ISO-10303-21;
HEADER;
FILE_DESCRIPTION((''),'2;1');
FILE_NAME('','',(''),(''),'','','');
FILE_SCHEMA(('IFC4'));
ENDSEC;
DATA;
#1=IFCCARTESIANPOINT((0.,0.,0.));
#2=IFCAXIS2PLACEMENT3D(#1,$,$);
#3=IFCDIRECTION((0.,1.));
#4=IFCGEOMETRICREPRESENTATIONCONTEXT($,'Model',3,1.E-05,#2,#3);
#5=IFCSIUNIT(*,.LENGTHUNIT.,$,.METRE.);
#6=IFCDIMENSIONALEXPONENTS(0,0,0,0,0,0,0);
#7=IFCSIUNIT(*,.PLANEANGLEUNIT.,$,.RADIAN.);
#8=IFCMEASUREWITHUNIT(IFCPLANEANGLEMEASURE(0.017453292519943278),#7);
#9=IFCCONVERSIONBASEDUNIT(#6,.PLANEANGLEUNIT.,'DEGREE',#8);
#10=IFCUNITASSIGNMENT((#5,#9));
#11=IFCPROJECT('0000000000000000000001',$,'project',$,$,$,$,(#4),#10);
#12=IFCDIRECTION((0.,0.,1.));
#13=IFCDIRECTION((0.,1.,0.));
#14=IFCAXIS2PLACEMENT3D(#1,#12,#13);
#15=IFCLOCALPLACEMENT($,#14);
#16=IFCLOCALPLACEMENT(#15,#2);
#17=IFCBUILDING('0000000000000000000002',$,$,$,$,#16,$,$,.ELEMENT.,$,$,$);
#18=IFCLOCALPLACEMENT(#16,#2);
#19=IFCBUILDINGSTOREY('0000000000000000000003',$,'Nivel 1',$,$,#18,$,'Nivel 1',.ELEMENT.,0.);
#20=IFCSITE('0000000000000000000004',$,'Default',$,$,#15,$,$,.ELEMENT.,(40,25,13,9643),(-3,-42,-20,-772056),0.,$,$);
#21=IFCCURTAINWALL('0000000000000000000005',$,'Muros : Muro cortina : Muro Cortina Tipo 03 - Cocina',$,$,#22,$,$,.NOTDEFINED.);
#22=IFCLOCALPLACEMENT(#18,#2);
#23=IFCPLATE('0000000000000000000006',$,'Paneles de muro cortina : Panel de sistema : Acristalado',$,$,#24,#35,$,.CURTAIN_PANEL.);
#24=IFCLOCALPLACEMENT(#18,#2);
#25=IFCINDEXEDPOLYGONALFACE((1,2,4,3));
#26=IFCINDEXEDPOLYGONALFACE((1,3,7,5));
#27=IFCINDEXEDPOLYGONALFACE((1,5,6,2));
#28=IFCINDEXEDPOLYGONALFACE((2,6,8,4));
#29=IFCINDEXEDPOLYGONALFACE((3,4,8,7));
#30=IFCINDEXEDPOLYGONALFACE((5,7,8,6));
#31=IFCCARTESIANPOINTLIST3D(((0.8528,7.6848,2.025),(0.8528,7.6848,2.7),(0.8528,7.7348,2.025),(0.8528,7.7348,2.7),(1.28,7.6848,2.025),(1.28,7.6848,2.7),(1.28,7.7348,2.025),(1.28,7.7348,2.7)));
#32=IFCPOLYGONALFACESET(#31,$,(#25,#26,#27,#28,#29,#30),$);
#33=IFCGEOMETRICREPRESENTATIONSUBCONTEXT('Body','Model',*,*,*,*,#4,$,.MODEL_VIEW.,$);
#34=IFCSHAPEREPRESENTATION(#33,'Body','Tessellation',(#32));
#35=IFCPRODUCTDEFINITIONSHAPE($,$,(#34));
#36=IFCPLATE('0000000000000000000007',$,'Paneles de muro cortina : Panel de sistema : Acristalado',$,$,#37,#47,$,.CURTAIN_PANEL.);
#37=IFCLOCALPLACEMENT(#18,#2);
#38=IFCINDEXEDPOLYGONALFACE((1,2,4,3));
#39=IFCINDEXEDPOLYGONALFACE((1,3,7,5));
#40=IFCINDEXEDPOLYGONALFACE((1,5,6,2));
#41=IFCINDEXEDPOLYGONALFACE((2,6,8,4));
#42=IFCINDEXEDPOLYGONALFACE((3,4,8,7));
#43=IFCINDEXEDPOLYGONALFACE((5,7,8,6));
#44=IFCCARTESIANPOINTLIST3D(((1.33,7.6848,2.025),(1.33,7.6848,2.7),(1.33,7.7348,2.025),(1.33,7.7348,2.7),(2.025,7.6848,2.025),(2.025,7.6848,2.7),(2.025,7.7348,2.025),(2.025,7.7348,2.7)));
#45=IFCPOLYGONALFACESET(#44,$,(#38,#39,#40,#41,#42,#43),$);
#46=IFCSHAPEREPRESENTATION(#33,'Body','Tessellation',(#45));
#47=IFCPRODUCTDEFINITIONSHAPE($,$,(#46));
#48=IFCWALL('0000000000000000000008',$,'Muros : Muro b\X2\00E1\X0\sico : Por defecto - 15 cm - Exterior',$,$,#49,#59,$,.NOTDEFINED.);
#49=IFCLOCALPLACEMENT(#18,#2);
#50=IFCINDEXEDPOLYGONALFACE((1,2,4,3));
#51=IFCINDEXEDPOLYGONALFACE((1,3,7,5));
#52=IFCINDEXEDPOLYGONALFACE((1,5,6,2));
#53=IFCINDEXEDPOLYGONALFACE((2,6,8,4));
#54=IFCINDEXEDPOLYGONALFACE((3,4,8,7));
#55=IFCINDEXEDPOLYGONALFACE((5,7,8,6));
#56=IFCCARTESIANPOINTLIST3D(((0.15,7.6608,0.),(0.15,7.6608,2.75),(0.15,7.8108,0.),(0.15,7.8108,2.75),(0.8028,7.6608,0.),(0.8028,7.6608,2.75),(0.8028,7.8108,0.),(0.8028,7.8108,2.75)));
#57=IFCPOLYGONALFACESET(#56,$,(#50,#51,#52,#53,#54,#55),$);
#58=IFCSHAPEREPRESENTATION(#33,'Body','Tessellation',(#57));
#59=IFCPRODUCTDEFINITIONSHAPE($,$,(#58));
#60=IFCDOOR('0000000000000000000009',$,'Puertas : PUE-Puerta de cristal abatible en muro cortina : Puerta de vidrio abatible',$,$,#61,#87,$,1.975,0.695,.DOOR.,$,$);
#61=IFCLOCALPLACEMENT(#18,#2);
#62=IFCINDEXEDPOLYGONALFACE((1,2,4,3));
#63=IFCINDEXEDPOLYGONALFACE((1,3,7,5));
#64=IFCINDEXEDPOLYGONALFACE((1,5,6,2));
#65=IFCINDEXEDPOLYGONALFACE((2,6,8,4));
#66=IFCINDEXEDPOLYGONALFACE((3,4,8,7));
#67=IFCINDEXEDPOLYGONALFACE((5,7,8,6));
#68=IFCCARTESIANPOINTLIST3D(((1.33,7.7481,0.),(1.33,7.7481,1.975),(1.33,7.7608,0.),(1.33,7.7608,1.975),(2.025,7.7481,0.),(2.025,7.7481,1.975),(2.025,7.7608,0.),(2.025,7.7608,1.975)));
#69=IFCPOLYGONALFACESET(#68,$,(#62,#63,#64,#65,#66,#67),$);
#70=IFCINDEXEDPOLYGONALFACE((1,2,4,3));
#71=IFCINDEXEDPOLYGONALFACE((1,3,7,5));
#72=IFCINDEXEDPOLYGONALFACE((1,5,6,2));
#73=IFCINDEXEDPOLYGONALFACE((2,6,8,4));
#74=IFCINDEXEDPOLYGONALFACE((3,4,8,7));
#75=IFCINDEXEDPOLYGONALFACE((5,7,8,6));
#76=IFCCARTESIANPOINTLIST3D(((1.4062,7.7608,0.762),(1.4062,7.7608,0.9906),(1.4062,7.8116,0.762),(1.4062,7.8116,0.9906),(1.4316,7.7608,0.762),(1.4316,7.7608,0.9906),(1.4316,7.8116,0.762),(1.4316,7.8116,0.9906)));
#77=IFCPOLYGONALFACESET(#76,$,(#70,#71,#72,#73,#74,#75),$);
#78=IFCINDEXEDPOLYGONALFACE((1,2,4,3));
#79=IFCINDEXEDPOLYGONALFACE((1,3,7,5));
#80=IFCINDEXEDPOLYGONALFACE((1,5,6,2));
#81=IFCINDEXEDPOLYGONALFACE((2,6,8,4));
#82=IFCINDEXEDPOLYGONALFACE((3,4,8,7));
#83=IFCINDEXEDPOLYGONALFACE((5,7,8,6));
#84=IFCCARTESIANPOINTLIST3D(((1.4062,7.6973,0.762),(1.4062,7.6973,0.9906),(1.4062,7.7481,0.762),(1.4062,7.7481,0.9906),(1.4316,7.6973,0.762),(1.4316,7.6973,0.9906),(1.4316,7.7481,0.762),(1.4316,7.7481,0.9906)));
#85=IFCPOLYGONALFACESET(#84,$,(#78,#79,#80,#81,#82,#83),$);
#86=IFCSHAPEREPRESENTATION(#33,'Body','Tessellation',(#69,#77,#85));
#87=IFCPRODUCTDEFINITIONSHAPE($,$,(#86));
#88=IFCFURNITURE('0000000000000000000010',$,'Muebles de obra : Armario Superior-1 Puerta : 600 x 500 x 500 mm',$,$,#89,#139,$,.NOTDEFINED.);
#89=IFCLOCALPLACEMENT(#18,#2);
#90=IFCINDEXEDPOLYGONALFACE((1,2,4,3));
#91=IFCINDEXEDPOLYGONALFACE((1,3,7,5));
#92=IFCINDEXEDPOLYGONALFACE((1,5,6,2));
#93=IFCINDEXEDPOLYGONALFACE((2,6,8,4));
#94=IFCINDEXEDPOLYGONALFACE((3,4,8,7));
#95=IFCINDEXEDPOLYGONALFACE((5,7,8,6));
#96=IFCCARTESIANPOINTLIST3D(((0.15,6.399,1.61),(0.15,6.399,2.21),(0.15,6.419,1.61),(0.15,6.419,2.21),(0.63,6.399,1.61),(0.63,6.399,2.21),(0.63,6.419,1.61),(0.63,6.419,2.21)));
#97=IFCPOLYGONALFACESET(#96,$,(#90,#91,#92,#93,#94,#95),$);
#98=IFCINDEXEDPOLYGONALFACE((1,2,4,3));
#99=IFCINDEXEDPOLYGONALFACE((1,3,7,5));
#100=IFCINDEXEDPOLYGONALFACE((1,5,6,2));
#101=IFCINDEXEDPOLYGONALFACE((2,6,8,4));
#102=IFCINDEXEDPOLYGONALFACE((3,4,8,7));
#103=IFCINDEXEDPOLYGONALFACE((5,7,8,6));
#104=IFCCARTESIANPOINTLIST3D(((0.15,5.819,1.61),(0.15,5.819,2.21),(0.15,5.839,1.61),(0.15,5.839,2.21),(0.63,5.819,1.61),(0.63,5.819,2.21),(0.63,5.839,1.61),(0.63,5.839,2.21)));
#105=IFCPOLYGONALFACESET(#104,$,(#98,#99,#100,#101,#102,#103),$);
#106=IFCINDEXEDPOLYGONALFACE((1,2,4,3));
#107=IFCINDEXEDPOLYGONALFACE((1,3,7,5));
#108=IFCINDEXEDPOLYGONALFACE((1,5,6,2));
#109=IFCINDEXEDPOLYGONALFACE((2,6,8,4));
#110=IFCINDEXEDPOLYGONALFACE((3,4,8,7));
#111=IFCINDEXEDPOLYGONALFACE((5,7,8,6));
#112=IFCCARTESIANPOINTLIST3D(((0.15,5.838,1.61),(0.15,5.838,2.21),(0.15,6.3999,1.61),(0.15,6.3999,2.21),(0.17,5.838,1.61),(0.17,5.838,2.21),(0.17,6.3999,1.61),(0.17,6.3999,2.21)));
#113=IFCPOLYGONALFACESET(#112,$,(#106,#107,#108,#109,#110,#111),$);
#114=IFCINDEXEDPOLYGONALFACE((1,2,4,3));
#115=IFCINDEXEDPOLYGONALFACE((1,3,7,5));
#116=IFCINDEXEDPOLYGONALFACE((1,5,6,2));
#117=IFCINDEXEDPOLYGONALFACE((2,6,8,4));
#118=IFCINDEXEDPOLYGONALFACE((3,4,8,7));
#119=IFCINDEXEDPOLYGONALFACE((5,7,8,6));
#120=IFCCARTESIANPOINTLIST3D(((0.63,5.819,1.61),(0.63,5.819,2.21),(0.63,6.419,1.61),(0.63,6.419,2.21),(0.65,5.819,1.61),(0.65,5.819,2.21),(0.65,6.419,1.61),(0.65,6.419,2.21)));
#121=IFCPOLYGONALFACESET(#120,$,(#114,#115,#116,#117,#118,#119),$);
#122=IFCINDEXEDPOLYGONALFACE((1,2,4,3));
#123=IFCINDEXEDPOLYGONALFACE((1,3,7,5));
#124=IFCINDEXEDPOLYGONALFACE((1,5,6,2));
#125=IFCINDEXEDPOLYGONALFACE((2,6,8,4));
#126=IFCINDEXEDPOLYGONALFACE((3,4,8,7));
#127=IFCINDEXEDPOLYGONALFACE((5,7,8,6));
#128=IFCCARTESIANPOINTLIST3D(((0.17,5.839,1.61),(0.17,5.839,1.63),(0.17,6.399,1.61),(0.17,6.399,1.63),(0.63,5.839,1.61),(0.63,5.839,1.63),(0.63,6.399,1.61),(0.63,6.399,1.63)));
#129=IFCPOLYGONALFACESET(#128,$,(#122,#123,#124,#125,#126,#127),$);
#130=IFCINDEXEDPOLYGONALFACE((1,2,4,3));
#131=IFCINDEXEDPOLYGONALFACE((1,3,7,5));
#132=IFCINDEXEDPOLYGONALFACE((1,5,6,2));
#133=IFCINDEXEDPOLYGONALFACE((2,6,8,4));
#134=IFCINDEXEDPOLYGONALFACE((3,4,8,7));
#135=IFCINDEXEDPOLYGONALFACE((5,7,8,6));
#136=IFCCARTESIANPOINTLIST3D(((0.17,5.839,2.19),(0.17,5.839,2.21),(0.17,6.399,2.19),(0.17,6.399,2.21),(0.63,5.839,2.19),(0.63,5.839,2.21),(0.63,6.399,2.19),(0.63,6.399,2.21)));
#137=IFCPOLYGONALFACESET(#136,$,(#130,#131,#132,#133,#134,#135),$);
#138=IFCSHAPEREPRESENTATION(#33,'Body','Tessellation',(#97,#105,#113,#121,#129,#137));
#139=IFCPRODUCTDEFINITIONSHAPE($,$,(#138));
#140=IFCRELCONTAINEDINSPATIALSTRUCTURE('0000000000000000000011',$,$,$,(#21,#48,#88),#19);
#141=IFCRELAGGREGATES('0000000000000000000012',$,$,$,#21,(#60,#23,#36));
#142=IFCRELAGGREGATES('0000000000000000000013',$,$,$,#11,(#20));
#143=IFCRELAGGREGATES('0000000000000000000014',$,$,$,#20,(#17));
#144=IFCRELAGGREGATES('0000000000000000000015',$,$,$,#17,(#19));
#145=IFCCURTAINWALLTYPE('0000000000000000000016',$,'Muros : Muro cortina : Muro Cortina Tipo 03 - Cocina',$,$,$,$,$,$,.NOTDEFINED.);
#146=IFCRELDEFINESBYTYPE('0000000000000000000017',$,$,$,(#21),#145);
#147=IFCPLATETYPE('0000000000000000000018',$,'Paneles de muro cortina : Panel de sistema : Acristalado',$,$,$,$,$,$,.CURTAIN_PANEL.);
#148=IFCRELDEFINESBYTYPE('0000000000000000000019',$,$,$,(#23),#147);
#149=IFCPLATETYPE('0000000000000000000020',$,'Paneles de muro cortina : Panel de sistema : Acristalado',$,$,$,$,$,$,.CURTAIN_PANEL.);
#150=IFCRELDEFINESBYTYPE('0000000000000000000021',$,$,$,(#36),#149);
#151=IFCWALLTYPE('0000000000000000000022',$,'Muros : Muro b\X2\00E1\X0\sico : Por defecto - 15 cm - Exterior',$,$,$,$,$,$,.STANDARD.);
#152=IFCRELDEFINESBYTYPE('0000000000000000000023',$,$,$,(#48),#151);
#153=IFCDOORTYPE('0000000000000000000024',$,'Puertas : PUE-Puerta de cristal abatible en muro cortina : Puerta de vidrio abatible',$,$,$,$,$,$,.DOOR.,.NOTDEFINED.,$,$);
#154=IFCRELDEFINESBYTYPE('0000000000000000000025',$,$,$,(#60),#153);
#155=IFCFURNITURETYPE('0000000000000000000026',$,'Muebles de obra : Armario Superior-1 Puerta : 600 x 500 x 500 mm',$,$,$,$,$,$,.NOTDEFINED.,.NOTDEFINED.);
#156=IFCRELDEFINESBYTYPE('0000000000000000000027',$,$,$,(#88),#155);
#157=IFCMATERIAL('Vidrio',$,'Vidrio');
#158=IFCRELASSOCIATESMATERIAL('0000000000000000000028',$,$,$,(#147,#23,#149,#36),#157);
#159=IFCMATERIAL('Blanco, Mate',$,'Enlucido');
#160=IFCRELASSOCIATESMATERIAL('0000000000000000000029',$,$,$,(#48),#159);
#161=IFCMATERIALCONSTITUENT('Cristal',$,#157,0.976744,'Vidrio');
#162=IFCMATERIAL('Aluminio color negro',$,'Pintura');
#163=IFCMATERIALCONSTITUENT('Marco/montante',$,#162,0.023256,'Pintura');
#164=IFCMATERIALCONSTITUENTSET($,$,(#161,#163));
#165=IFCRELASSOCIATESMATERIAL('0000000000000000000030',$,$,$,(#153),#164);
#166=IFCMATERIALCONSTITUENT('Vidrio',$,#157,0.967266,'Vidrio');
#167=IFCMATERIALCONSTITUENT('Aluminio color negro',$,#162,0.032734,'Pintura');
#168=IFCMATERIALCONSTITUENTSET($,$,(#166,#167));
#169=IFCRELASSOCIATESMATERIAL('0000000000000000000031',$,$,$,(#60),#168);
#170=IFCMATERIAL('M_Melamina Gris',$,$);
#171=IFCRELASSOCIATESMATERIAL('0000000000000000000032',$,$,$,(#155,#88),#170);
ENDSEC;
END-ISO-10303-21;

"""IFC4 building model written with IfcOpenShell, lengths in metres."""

from ifc_helpers import new_model, entity, si_unit, converted_unit, direction, frame, origin, place, context, subcontext, project, spatial, indexed_curve, outline, extrude, source, transform, mapped, material, constituent, constituent_set, type_object, type_shapes, element, aggregate, save


model = new_model("IFC4")

# Units and contexts
model_context = context("Model", 3, precision=1e-05, world=origin(), true_north=direction((0.0, 1.0)))
body_context = subcontext(model_context, "Body", "Model", "MODEL_VIEW")
ifc_project = project(units=[si_unit("LENGTHUNIT", "METRE"), converted_unit("PLANEANGLEUNIT", "DEGREE", entity("IfcPlaneAngleMeasure", 0.017453292519943278), si_unit("PLANEANGLEUNIT", "RADIAN"), dimensions=[0, 0, 0, 0, 0, 0, 0])], contexts=[model_context])

# Site, building, storey
site_placement = place(None, frame((0.0, 0.0, 0.0), z_axis=(0.0, 0.0, 1.0), x_axis=(0.0, 1.0, 0.0)))
site = spatial("IfcSite", under=ifc_project, at=site_placement, Name="Default", CompositionType="ELEMENT", RefLatitude=(40, 25, 13, 9643), RefLongitude=(-3, -42, -20, -772056), RefElevation=0.0)
building_placement = place(site_placement, origin())
building = spatial("IfcBuilding", under=site, at=building_placement, CompositionType="ELEMENT")
storey_placement = place(building_placement, origin())
storey = spatial("IfcBuildingStorey", under=building, at=storey_placement, Name="Nivel 1", LongName="Nivel 1", CompositionType="ELEMENT", Elevation=0.0)

# Shared definitions
ifc_material_1 = material(Name="Blanco, Mate", Category="Enlucido")

# Curtain wall, plates
curtain_wall_type_1 = type_object("IfcCurtainWallType", Name="Muros : Muro cortina : Muro Cortina Tipo 03 - Cocina", PredefinedType="NOTDEFINED")
curtain_wall_1_placement = place(storey_placement, origin())
curtain_wall_1 = element("IfcCurtainWall", 1, at=curtain_wall_1_placement, inside=storey, type_object=curtain_wall_type_1, Name="Muros : Muro cortina : Muro Cortina Tipo 03 - Cocina", PredefinedType="NOTDEFINED")
ifc_material_2 = material(Name="Aluminio color negro", Category="Pintura")
ifc_material_3 = material(Name="Vidrio", Category="Vidrio")
plate_type_1 = type_object("IfcPlateType", Name="Paneles de muro cortina : Panel de sistema : Acristalado", PredefinedType="CURTAIN_PANEL", material=ifc_material_3)
shared_shape_1 = source(origin(), body_context, "Body", "SweptSolid", [
    extrude(outline(indexed_curve([(-0.025, -0.2136), (0.025, -0.2136), (0.025, 0.2136), (-0.025, 0.2136), (-0.025, -0.2136)], self_intersect=False)), frame((0.0, 0.0, 0.0), z_axis=(0.0, 0.0, 1.0), x_axis=(0.0, 1.0, 0.0)), (0.0, 0.0, 1.0), 0.675),
])
type_shapes(plate_type_1, [shared_shape_1])
plate_1_placement = place(curtain_wall_1_placement, frame((1.0664, 7.7098, 2.025)))
plate_1 = element("IfcPlate", 2, at=plate_1_placement, type_object=plate_type_1, material=ifc_material_3, Name="Paneles de muro cortina : Panel de sistema : Acristalado", PredefinedType="CURTAIN_PANEL", context=body_context, shape_type="MappedRepresentation", body=[
    mapped(shared_shape_1, transform((0.0, 0.0, 0.0), scale=1.0)),
])
plate_type_2 = type_object("IfcPlateType", Name="Paneles de muro cortina : Panel de sistema : Acristalado", PredefinedType="CURTAIN_PANEL", material=ifc_material_3)
shared_shape_2 = source(origin(), body_context, "Body", "SweptSolid", [
    extrude(outline(indexed_curve([(-0.025, -0.3475), (0.025, -0.3475), (0.025, 0.3475), (-0.025, 0.3475), (-0.025, -0.3475)], self_intersect=False)), frame((0.0, 0.0, 0.0), z_axis=(0.0, 0.0, 1.0), x_axis=(0.0, 1.0, 0.0)), (0.0, 0.0, 1.0), 0.675),
])
type_shapes(plate_type_2, [shared_shape_2])
plate_2_placement = place(curtain_wall_1_placement, frame((1.6775, 7.7098, 2.025)))
plate_2 = element("IfcPlate", 3, at=plate_2_placement, type_object=plate_type_2, material=ifc_material_3, Name="Paneles de muro cortina : Panel de sistema : Acristalado", PredefinedType="CURTAIN_PANEL", context=body_context, shape_type="MappedRepresentation", body=[
    mapped(shared_shape_2, transform((0.0, 0.0, 0.0), scale=1.0)),
])

# Wall
wall_type = type_object("IfcWallType", Name="Muros : Muro básico : Por defecto - 15 cm - Exterior", PredefinedType="STANDARD")
wall_placement = place(storey_placement, frame((0.15, 7.7358, 0.0)))
element("IfcWall", 4, at=wall_placement, inside=storey, type_object=wall_type, material=ifc_material_1, Name="Muros : Muro básico : Por defecto - 15 cm - Exterior", PredefinedType="NOTDEFINED", context=body_context, shape_type="SweptSolid", body=[
    extrude(outline(indexed_curve([(0.6528, 0.075), (0.0, 0.075), (0.0, -0.075), (0.6528, -0.075), (0.6528, 0.075)], self_intersect=False)), origin(), (0.0, 0.0, 1.0), 2.75),
])

# Door
ifc_constituent_1 = constituent(ifc_material_3, Name="Vidrio", Category="Vidrio", fraction=0.967266)
ifc_constituent_2 = constituent(ifc_material_2, Name="Aluminio color negro", Category="Pintura", fraction=0.032734)
ifc_constituent_set_1 = constituent_set(constituents=[ifc_constituent_1, ifc_constituent_2])
ifc_constituent_3 = constituent(ifc_material_3, Name="Cristal", Category="Vidrio", fraction=0.976744)
ifc_constituent_4 = constituent(ifc_material_2, Name="Marco/montante", Category="Pintura", fraction=0.023256)
ifc_constituent_set_2 = constituent_set(constituents=[ifc_constituent_3, ifc_constituent_4])
door_type = type_object("IfcDoorType", Name="Puertas : PUE-Puerta de cristal abatible en muro cortina : Puerta de vidrio abatible", OperationType="NOTDEFINED", PredefinedType="DOOR", material=ifc_constituent_set_2)
shared_shape_3 = source(origin(), body_context, "Body", "SweptSolid", [
    extrude(outline(indexed_curve([(-0.3475, -0.0064), (0.3475, -0.0064), (0.3475, 0.0064), (-0.3475, 0.0064), (-0.3475, -0.0064)], self_intersect=False)), frame((0.0, 0.0447, 0.0), z_axis=(0.0, 0.0, 1.0), x_axis=(-1.0, 0.0, 0.0)), (0.0, 0.0, 1.0), 1.975),
    extrude(outline(indexed_curve([(-0.0254, -0.0127), (0.0254, -0.0127), (0.0254, 0.0127), (-0.0254, 0.0127), (-0.0254, -0.0127)], self_intersect=False)), frame((-0.2586, 0.0764, 0.762), z_axis=(0.0, 0.0, 1.0), x_axis=(0.0, -1.0, 0.0)), (0.0, 0.0, 1.0), 0.2286),
    extrude(outline(indexed_curve([(-0.0254, -0.0127), (0.0254, -0.0127), (0.0254, 0.0127), (-0.0254, 0.0127), (-0.0254, -0.0127)], self_intersect=False)), frame((-0.2586, 0.0129, 0.762), z_axis=(0.0, 0.0, 1.0), x_axis=(0.0, 1.0, 0.0)), (0.0, 0.0, 1.0), 0.2286),
])
type_shapes(door_type, [shared_shape_3])
door_placement = place(curtain_wall_1_placement, frame((1.6775, 7.7098, 0.0)))
door = element("IfcDoor", 5, at=door_placement, type_object=door_type, material=ifc_constituent_set_1, Name="Puertas : PUE-Puerta de cristal abatible en muro cortina : Puerta de vidrio abatible", OverallHeight=1.975, OverallWidth=0.695, PredefinedType="DOOR", context=body_context, shape_type="MappedRepresentation", body=[
    mapped(shared_shape_3, transform((0.0, 0.0, 0.0), scale=1.0)),
])
aggregate(curtain_wall_1, [door, plate_1, plate_2])

# Furniture
ifc_material_4 = material(Name="M_Melamina Gris")
furniture_type_1 = type_object("IfcFurnitureType", Name="Muebles de obra : Armario Superior-1 Puerta : 600 x 500 x 500 mm", AssemblyPlace="NOTDEFINED", PredefinedType="NOTDEFINED", material=ifc_material_4)
shared_shape_4 = source(origin(), body_context, "Body", "SweptSolid", [
    extrude(outline(indexed_curve([(-0.01, -0.24), (0.01, -0.24), (0.01, 0.24), (-0.01, 0.24), (-0.01, -0.24)], self_intersect=False)), frame((-0.4213, 0.24, 0.0), z_axis=(0.0, 0.0, 1.0), x_axis=(-1.0, 0.0, 0.0)), (0.0, 0.0, 1.0), 0.6),
    extrude(outline(indexed_curve([(-0.24, -0.01), (0.24, -0.01), (0.24, 0.01), (-0.24, 0.01), (-0.24, -0.01)], self_intersect=False)), frame((0.1587, 0.24, 0.0), z_axis=(0.0, 0.0, 1.0), x_axis=(0.0, -1.0, 0.0)), (0.0, 0.0, 1.0), 0.6),
    extrude(outline(indexed_curve([(-0.281, -0.01), (0.281, -0.01), (0.281, 0.01), (-0.281, 0.01), (-0.281, -0.01)], self_intersect=False)), frame((-0.1313, 0.01, 0.0)), (0.0, 0.0, 1.0), 0.6),
    extrude(outline(indexed_curve([(-0.3, -0.01), (0.3, -0.01), (0.3, 0.01), (-0.3, 0.01), (-0.3, -0.01)], self_intersect=False)), frame((-0.1313, 0.49, 0.0)), (0.0, 0.0, 1.0), 0.6),
    extrude(outline(indexed_curve([(-0.23, -0.28), (0.23, -0.28), (0.23, 0.28), (-0.23, 0.28), (-0.23, -0.28)], self_intersect=False)), frame((-0.1313, 0.25, 0.0), z_axis=(0.0, 0.0, 1.0), x_axis=(0.0, 1.0, 0.0)), (0.0, 0.0, 1.0), 0.02),
    extrude(outline(indexed_curve([(-0.23, -0.28), (0.23, -0.28), (0.23, 0.28), (-0.23, 0.28), (-0.23, -0.28)], self_intersect=False)), frame((-0.1313, 0.25, 0.58), z_axis=(0.0, 0.0, 1.0), x_axis=(0.0, 1.0, 0.0)), (0.0, 0.0, 1.0), 0.02),
])
type_shapes(furniture_type_1, [shared_shape_4])
furniture_1_placement = place(storey_placement, frame((0.15, 5.9877, 1.61), z_axis=(0.0, 0.0, 1.0), x_axis=(0.0, -1.0, 0.0)))
element("IfcFurniture", 6, at=furniture_1_placement, inside=storey, type_object=furniture_type_1, material=ifc_material_4, Name="Muebles de obra : Armario Superior-1 Puerta : 600 x 500 x 500 mm", PredefinedType="NOTDEFINED", context=body_context, shape_type="MappedRepresentation", body=[
    mapped(shared_shape_4, transform((0.0, 0.0, 0.0), scale=1.0)),
])

save(model, "model.ifc")
